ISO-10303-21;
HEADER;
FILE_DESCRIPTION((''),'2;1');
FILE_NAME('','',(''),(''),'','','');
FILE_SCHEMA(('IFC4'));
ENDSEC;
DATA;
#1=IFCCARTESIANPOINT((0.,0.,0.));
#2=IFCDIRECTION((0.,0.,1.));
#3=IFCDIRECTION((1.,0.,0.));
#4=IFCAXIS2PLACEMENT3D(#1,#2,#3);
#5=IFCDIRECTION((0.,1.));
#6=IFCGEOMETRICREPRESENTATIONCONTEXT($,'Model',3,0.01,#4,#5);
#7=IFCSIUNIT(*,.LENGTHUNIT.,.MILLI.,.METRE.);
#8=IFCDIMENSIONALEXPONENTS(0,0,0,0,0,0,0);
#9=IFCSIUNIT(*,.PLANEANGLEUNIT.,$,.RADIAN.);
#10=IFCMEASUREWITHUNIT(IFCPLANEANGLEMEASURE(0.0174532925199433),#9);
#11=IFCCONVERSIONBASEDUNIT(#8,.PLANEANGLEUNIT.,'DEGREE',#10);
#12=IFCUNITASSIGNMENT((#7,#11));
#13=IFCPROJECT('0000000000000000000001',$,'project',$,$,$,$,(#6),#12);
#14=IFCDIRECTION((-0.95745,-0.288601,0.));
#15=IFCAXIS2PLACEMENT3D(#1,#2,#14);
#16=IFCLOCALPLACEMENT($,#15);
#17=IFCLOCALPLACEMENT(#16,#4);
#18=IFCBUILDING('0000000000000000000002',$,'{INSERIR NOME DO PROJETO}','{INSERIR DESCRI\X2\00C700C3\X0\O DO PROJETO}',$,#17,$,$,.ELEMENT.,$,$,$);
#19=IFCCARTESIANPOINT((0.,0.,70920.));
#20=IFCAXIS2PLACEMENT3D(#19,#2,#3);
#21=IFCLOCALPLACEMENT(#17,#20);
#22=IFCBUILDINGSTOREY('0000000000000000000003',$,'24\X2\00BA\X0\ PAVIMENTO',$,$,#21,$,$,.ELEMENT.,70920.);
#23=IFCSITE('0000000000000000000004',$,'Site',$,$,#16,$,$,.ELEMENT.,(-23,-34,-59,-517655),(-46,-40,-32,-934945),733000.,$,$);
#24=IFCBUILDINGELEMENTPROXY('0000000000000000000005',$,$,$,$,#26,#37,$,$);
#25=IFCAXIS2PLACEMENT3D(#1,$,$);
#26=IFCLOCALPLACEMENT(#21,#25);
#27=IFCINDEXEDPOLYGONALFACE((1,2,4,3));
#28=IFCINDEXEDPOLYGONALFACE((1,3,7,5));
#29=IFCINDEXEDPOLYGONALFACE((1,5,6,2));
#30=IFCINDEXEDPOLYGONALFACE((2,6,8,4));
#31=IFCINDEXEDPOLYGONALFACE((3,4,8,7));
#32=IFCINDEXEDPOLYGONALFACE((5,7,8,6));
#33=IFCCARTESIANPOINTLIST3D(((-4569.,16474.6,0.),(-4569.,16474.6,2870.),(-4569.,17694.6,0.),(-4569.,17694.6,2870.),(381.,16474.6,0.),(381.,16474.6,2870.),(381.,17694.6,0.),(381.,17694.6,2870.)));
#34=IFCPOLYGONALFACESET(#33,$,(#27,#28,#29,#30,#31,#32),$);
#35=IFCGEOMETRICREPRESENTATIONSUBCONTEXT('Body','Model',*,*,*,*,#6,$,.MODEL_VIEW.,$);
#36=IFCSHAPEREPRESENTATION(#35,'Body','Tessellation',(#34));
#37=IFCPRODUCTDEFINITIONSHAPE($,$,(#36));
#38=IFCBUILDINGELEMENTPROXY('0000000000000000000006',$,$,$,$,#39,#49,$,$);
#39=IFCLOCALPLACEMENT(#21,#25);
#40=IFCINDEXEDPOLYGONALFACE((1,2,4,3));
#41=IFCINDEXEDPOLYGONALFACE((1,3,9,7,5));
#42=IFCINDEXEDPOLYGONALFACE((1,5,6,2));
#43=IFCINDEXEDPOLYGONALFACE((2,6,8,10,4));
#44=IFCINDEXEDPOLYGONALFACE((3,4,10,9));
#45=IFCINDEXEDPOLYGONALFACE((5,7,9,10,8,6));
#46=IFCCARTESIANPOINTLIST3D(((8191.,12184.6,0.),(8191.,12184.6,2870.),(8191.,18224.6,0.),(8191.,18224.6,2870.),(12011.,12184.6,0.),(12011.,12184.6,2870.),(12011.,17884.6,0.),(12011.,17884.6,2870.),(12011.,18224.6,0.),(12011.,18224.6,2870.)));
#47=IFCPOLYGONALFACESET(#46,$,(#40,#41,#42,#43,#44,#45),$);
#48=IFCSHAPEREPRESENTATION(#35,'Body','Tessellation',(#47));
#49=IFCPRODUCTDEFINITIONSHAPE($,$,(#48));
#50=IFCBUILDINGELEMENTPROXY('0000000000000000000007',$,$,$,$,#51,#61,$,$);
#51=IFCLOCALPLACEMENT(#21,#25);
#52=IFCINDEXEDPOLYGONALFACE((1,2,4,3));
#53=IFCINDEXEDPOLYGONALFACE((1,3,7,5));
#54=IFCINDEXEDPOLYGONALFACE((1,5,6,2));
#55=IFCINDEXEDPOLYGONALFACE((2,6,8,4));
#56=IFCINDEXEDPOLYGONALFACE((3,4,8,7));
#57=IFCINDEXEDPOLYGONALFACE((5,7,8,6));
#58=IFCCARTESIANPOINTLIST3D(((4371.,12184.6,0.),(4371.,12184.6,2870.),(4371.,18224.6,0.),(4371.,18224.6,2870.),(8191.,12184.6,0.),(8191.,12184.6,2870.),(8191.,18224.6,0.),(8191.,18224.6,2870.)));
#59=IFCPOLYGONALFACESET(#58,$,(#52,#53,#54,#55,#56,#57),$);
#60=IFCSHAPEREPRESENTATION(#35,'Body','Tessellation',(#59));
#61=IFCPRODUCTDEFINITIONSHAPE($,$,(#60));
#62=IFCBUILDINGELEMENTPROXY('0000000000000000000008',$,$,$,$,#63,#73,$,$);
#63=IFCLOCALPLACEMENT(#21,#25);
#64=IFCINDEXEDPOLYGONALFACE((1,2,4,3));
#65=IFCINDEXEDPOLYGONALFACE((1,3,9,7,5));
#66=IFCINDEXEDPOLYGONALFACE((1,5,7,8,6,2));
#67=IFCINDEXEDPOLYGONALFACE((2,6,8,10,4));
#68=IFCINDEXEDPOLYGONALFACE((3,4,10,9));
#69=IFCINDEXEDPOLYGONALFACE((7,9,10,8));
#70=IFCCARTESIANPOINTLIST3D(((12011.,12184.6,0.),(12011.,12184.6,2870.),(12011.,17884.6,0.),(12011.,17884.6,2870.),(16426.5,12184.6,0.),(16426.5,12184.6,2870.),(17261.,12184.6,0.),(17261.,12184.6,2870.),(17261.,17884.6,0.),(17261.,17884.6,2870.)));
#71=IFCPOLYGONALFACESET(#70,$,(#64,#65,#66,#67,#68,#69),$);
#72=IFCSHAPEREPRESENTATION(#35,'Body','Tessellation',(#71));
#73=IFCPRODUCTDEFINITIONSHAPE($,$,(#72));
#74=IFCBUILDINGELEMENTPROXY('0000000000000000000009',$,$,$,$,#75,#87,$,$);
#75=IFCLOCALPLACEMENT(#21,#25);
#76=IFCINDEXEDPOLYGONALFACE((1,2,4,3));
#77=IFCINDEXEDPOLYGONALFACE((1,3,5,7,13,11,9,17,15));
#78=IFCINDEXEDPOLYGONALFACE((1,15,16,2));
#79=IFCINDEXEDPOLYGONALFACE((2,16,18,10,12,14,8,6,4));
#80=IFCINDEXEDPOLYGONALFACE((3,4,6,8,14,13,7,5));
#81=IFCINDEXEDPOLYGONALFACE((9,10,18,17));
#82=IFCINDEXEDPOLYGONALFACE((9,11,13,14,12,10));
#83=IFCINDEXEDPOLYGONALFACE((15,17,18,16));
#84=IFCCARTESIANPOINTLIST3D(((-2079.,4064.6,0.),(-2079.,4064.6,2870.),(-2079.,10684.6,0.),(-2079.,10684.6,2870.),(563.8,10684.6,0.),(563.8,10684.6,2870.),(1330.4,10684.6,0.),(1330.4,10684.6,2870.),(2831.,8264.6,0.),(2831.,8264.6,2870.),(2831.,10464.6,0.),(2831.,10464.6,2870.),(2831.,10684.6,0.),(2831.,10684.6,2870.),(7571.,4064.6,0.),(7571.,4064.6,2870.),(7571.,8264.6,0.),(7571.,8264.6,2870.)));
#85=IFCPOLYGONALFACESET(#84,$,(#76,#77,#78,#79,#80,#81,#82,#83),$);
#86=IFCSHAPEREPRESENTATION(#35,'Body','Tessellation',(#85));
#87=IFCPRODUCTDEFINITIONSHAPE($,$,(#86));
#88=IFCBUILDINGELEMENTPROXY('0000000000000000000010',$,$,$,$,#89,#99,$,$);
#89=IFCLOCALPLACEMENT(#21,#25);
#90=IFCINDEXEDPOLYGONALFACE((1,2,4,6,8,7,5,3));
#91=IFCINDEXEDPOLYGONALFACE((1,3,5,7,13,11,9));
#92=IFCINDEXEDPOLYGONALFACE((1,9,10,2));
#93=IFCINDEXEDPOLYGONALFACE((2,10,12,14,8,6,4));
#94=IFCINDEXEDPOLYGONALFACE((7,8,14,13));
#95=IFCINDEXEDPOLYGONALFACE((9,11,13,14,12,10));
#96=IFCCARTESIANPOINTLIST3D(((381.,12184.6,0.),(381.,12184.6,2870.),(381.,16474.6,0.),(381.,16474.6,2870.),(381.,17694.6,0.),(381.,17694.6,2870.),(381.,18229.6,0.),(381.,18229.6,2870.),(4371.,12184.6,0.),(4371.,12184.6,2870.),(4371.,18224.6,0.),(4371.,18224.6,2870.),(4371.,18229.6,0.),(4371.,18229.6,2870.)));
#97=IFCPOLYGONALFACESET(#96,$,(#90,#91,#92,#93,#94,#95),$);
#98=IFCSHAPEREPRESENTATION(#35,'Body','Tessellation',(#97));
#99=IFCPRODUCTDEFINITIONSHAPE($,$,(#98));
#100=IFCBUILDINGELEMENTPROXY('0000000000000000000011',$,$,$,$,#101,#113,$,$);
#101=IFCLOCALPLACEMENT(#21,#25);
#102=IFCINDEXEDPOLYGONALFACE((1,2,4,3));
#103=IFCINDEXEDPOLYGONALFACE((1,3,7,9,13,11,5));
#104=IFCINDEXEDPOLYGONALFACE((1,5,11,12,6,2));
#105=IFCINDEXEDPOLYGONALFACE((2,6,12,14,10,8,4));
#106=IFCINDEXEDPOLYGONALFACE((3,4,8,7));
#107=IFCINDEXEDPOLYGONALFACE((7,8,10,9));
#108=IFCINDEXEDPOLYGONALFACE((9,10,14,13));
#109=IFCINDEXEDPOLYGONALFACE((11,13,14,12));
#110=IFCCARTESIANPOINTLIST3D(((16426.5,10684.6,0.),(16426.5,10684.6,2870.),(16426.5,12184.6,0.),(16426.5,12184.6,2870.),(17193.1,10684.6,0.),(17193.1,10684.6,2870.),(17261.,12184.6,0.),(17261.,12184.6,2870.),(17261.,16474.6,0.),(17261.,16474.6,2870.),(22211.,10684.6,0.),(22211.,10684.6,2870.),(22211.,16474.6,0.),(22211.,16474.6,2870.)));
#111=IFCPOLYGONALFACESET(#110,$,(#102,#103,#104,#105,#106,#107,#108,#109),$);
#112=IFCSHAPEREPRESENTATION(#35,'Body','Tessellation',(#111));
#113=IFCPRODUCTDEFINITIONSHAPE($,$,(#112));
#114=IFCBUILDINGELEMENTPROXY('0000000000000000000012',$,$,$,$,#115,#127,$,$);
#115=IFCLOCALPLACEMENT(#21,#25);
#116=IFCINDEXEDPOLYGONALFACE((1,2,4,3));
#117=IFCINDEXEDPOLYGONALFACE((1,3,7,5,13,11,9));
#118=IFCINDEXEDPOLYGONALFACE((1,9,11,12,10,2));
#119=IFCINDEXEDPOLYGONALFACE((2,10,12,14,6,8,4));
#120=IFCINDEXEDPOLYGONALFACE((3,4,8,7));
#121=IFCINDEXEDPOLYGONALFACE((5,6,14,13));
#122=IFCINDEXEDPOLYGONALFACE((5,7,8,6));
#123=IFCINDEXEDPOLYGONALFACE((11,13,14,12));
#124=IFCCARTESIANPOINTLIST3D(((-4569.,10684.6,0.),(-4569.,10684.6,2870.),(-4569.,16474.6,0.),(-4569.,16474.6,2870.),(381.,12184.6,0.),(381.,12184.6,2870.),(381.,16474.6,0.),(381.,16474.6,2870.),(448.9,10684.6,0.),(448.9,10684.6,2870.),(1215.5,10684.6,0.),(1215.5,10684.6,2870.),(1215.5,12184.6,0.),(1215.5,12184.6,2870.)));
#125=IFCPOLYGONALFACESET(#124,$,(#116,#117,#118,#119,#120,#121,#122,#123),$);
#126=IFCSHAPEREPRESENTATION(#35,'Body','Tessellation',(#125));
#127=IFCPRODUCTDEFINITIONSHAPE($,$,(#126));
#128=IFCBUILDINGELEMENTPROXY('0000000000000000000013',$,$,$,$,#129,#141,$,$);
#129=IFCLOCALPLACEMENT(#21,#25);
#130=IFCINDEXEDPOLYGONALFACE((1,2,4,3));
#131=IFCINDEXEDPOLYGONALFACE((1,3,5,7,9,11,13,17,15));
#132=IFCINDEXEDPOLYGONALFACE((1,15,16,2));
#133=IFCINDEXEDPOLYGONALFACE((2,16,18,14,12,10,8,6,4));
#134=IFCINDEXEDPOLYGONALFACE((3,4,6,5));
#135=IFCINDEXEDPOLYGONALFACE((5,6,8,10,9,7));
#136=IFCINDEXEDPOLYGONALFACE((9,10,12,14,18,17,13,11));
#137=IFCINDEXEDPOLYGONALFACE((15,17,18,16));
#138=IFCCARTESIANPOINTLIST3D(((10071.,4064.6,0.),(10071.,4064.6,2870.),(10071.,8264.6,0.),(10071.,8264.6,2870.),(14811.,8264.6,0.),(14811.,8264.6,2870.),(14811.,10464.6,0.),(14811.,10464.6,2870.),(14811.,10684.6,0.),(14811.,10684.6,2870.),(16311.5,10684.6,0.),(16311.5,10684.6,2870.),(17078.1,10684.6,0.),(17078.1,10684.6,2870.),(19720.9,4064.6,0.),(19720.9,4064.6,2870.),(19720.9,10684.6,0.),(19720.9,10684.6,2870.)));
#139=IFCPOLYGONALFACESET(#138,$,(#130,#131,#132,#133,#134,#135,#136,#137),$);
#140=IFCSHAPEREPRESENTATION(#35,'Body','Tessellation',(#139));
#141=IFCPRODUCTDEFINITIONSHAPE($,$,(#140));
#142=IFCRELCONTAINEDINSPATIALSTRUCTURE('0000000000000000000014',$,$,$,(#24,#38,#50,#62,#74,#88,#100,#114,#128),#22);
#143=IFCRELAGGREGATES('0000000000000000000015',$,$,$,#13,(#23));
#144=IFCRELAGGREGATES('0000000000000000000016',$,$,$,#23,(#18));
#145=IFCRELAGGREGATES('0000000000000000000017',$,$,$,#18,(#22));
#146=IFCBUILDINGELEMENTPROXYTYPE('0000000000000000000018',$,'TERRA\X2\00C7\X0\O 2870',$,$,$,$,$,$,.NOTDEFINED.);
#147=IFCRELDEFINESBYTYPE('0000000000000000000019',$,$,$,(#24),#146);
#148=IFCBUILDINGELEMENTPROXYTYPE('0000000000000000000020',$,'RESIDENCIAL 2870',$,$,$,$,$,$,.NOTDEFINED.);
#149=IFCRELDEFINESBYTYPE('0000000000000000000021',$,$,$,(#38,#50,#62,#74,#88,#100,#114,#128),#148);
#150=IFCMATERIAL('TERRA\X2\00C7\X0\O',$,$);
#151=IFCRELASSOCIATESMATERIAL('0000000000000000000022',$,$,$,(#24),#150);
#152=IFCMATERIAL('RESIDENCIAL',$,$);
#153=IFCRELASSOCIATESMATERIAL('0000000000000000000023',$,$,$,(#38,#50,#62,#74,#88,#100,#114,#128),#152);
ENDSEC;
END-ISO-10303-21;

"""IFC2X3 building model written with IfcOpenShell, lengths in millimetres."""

from ifc_helpers import new_model, entity, si_unit, converted_unit, direction, frame, origin_with_axes, place, context, subcontext, project, spatial, polyline, outline, extrude, material, type_object, element, save


model = new_model("IFC2X3")

# Units and contexts
model_context = context("Model", 3, precision=0.01, world=origin_with_axes(), true_north=direction((0.0, 1.0)))
body_context = subcontext(model_context, "Body", "Model", "MODEL_VIEW")
ifc_project = project(units=[si_unit("LENGTHUNIT", "METRE", prefix="MILLI"), converted_unit("PLANEANGLEUNIT", "DEGREE", entity("IfcPlaneAngleMeasure", 0.0174532925199433), si_unit("PLANEANGLEUNIT", "RADIAN"), dimensions=[0, 0, 0, 0, 0, 0, 0])], contexts=[model_context])

# Site, building, storey
site_placement = place(None, frame((0.0, 0.0, 0.0), z_axis=(0.0, 0.0, 1.0), x_axis=(-0.95745, -0.288601, 0.0)))
site = spatial("IfcSite", under=ifc_project, at=site_placement, Name="Site", CompositionType="ELEMENT", RefLatitude=(-23, -34, -59, -517655), RefLongitude=(-46, -40, -32, -934945), RefElevation=733000.0)
building_placement = place(site_placement, origin_with_axes())
building = spatial("IfcBuilding", under=site, at=building_placement, Name="{INSERIR NOME DO PROJETO}", Description="{INSERIR DESCRIÇÃO DO PROJETO}", CompositionType="ELEMENT")
storey_placement = place(building_placement, frame((0.0, 0.0, 70920.0), z_axis=(0.0, 0.0, 1.0), x_axis=(1.0, 0.0, 0.0)))
storey = spatial("IfcBuildingStorey", under=building, at=storey_placement, Name="24º PAVIMENTO", CompositionType="ELEMENT", Elevation=70920.0)

# Building element proxies
ifc_material_1 = material(Name="TERRAÇO")
building_element_proxy_type_1 = type_object("IfcBuildingElementProxyType", Name="TERRAÇO 2870", PredefinedType="NOTDEFINED")
proxy_1_placement = place(storey_placement, frame((381.0, 17694.6, 0.0), z_axis=(0.0, 0.0, 1.0), x_axis=(1.0, 0.0, 0.0)))
element("IfcBuildingElementProxy", 1, at=proxy_1_placement, inside=storey, type_object=building_element_proxy_type_1, material=ifc_material_1, context=body_context, shape_type="SweptSolid", body=[
    extrude(outline(polyline([(0.0, 0.0), (-4950.0, 0.0), (-4950.0, -1220.0), (0.0, -1220.0), (0.0, 0.0)])), origin_with_axes(), (0.0, 0.0, 1.0), 2870.0),
])
ifc_material_2 = material(Name="RESIDENCIAL")
building_element_proxy_type_2 = type_object("IfcBuildingElementProxyType", Name="RESIDENCIAL 2870", PredefinedType="NOTDEFINED")
proxy_2_placement = place(storey_placement, frame((8191.0, 18224.6, 0.0), z_axis=(0.0, 0.0, 1.0), x_axis=(1.0, 0.0, 0.0)))
element("IfcBuildingElementProxy", 2, at=proxy_2_placement, inside=storey, type_object=building_element_proxy_type_2, material=ifc_material_2, context=body_context, shape_type="SweptSolid", body=[
    extrude(outline(polyline([(0.0, 0.0), (0.0, -6040.0), (3820.0, -6040.0), (3820.0, -340.0), (3820.0, 0.0), (0.0, 0.0)])), origin_with_axes(), (0.0, 0.0, 1.0), 2870.0),
])
proxy_3_placement = place(storey_placement, frame((4371.0, 18224.6, 0.0), z_axis=(0.0, 0.0, 1.0), x_axis=(1.0, 0.0, 0.0)))
element("IfcBuildingElementProxy", 3, at=proxy_3_placement, inside=storey, type_object=building_element_proxy_type_2, material=ifc_material_2, context=body_context, shape_type="SweptSolid", body=[
    extrude(outline(polyline([(0.0, 0.0), (0.0, -6040.0), (3820.0, -6040.0), (3820.0, 0.0), (0.0, 0.0)])), origin_with_axes(), (0.0, 0.0, 1.0), 2870.0),
])
proxy_4_placement = place(storey_placement, frame((12011.0, 12184.6, 0.0), z_axis=(0.0, 0.0, 1.0), x_axis=(1.0, 0.0, 0.0)))
element("IfcBuildingElementProxy", 4, at=proxy_4_placement, inside=storey, type_object=building_element_proxy_type_2, material=ifc_material_2, context=body_context, shape_type="SweptSolid", body=[
    extrude(outline(polyline([(0.0, 0.0), (4415.5, 0.0), (5250.0, 0.0), (5250.0, 5700.0), (0.0, 5700.0), (0.0, 0.0)])), origin_with_axes(), (0.0, 0.0, 1.0), 2870.0),
])
proxy_5_placement = place(storey_placement, frame((-2079.0, 4064.6, 0.0), z_axis=(0.0, 0.0, 1.0), x_axis=(1.0, 0.0, 0.0)))
element("IfcBuildingElementProxy", 5, at=proxy_5_placement, inside=storey, type_object=building_element_proxy_type_2, material=ifc_material_2, context=body_context, shape_type="SweptSolid", body=[
    extrude(outline(polyline([(0.0, 0.0), (9650.0, 0.0), (9650.0, 4200.0), (4910.0, 4200.0), (4910.0, 6400.0), (4910.0, 6620.0), (3409.4, 6620.0), (2642.8, 6620.0), (0.0, 6620.0), (0.0, 0.0)])), origin_with_axes(), (0.0, 0.0, 1.0), 2870.0),
])
proxy_6_placement = place(storey_placement, frame((381.0, 16474.6, 0.0), z_axis=(0.0, 0.0, 1.0), x_axis=(1.0, 0.0, 0.0)))
element("IfcBuildingElementProxy", 6, at=proxy_6_placement, inside=storey, type_object=building_element_proxy_type_2, material=ifc_material_2, context=body_context, shape_type="SweptSolid", body=[
    extrude(outline(polyline([(0.0, 0.0), (0.0, -4290.0), (3990.0, -4290.0), (3990.0, 1750.0), (3990.0, 1755.0), (0.0, 1755.0), (0.0, 1220.0), (0.0, 0.0)])), origin_with_axes(), (0.0, 0.0, 1.0), 2870.0),
])
proxy_7_placement = place(storey_placement, frame((17261.0, 12184.6, 0.0), z_axis=(0.0, 0.0, 1.0), x_axis=(1.0, 0.0, 0.0)))
element("IfcBuildingElementProxy", 7, at=proxy_7_placement, inside=storey, type_object=building_element_proxy_type_2, material=ifc_material_2, context=body_context, shape_type="SweptSolid", body=[
    extrude(outline(polyline([(0.0, 0.0), (-834.5, 0.0), (-834.5, -1500.0), (-67.9, -1500.0), (4950.0, -1500.0), (4950.0, 4290.0), (0.0, 4290.0), (0.0, 0.0)])), origin_with_axes(), (0.0, 0.0, 1.0), 2870.0),
])
proxy_8_placement = place(storey_placement, frame((-4569.0, 16474.6, 0.0), z_axis=(0.0, 0.0, 1.0), x_axis=(1.0, 0.0, 0.0)))
element("IfcBuildingElementProxy", 8, at=proxy_8_placement, inside=storey, type_object=building_element_proxy_type_2, material=ifc_material_2, context=body_context, shape_type="SweptSolid", body=[
    extrude(outline(polyline([(0.0, 0.0), (0.0, -5790.0), (5017.9, -5790.0), (5784.5, -5790.0), (5784.5, -4290.0), (4950.0, -4290.0), (4950.0, 0.0), (0.0, 0.0)])), origin_with_axes(), (0.0, 0.0, 1.0), 2870.0),
])
proxy_9_placement = place(storey_placement, frame((19720.9, 4064.6, 0.0), z_axis=(0.0, 0.0, 1.0), x_axis=(1.0, 0.0, 0.0)))
element("IfcBuildingElementProxy", 9, at=proxy_9_placement, inside=storey, type_object=building_element_proxy_type_2, material=ifc_material_2, context=body_context, shape_type="SweptSolid", body=[
    extrude(outline(polyline([(0.0, 0.0), (0.0, 6620.0), (-2642.8, 6620.0), (-3409.4, 6620.0), (-4910.0, 6620.0), (-4910.0, 6400.0), (-4910.0, 4200.0), (-9650.0, 4200.0), (-9650.0, 0.0), (0.0, 0.0)])), origin_with_axes(), (0.0, 0.0, 1.0), 2870.0),
])

save(model, "model.ifc")
